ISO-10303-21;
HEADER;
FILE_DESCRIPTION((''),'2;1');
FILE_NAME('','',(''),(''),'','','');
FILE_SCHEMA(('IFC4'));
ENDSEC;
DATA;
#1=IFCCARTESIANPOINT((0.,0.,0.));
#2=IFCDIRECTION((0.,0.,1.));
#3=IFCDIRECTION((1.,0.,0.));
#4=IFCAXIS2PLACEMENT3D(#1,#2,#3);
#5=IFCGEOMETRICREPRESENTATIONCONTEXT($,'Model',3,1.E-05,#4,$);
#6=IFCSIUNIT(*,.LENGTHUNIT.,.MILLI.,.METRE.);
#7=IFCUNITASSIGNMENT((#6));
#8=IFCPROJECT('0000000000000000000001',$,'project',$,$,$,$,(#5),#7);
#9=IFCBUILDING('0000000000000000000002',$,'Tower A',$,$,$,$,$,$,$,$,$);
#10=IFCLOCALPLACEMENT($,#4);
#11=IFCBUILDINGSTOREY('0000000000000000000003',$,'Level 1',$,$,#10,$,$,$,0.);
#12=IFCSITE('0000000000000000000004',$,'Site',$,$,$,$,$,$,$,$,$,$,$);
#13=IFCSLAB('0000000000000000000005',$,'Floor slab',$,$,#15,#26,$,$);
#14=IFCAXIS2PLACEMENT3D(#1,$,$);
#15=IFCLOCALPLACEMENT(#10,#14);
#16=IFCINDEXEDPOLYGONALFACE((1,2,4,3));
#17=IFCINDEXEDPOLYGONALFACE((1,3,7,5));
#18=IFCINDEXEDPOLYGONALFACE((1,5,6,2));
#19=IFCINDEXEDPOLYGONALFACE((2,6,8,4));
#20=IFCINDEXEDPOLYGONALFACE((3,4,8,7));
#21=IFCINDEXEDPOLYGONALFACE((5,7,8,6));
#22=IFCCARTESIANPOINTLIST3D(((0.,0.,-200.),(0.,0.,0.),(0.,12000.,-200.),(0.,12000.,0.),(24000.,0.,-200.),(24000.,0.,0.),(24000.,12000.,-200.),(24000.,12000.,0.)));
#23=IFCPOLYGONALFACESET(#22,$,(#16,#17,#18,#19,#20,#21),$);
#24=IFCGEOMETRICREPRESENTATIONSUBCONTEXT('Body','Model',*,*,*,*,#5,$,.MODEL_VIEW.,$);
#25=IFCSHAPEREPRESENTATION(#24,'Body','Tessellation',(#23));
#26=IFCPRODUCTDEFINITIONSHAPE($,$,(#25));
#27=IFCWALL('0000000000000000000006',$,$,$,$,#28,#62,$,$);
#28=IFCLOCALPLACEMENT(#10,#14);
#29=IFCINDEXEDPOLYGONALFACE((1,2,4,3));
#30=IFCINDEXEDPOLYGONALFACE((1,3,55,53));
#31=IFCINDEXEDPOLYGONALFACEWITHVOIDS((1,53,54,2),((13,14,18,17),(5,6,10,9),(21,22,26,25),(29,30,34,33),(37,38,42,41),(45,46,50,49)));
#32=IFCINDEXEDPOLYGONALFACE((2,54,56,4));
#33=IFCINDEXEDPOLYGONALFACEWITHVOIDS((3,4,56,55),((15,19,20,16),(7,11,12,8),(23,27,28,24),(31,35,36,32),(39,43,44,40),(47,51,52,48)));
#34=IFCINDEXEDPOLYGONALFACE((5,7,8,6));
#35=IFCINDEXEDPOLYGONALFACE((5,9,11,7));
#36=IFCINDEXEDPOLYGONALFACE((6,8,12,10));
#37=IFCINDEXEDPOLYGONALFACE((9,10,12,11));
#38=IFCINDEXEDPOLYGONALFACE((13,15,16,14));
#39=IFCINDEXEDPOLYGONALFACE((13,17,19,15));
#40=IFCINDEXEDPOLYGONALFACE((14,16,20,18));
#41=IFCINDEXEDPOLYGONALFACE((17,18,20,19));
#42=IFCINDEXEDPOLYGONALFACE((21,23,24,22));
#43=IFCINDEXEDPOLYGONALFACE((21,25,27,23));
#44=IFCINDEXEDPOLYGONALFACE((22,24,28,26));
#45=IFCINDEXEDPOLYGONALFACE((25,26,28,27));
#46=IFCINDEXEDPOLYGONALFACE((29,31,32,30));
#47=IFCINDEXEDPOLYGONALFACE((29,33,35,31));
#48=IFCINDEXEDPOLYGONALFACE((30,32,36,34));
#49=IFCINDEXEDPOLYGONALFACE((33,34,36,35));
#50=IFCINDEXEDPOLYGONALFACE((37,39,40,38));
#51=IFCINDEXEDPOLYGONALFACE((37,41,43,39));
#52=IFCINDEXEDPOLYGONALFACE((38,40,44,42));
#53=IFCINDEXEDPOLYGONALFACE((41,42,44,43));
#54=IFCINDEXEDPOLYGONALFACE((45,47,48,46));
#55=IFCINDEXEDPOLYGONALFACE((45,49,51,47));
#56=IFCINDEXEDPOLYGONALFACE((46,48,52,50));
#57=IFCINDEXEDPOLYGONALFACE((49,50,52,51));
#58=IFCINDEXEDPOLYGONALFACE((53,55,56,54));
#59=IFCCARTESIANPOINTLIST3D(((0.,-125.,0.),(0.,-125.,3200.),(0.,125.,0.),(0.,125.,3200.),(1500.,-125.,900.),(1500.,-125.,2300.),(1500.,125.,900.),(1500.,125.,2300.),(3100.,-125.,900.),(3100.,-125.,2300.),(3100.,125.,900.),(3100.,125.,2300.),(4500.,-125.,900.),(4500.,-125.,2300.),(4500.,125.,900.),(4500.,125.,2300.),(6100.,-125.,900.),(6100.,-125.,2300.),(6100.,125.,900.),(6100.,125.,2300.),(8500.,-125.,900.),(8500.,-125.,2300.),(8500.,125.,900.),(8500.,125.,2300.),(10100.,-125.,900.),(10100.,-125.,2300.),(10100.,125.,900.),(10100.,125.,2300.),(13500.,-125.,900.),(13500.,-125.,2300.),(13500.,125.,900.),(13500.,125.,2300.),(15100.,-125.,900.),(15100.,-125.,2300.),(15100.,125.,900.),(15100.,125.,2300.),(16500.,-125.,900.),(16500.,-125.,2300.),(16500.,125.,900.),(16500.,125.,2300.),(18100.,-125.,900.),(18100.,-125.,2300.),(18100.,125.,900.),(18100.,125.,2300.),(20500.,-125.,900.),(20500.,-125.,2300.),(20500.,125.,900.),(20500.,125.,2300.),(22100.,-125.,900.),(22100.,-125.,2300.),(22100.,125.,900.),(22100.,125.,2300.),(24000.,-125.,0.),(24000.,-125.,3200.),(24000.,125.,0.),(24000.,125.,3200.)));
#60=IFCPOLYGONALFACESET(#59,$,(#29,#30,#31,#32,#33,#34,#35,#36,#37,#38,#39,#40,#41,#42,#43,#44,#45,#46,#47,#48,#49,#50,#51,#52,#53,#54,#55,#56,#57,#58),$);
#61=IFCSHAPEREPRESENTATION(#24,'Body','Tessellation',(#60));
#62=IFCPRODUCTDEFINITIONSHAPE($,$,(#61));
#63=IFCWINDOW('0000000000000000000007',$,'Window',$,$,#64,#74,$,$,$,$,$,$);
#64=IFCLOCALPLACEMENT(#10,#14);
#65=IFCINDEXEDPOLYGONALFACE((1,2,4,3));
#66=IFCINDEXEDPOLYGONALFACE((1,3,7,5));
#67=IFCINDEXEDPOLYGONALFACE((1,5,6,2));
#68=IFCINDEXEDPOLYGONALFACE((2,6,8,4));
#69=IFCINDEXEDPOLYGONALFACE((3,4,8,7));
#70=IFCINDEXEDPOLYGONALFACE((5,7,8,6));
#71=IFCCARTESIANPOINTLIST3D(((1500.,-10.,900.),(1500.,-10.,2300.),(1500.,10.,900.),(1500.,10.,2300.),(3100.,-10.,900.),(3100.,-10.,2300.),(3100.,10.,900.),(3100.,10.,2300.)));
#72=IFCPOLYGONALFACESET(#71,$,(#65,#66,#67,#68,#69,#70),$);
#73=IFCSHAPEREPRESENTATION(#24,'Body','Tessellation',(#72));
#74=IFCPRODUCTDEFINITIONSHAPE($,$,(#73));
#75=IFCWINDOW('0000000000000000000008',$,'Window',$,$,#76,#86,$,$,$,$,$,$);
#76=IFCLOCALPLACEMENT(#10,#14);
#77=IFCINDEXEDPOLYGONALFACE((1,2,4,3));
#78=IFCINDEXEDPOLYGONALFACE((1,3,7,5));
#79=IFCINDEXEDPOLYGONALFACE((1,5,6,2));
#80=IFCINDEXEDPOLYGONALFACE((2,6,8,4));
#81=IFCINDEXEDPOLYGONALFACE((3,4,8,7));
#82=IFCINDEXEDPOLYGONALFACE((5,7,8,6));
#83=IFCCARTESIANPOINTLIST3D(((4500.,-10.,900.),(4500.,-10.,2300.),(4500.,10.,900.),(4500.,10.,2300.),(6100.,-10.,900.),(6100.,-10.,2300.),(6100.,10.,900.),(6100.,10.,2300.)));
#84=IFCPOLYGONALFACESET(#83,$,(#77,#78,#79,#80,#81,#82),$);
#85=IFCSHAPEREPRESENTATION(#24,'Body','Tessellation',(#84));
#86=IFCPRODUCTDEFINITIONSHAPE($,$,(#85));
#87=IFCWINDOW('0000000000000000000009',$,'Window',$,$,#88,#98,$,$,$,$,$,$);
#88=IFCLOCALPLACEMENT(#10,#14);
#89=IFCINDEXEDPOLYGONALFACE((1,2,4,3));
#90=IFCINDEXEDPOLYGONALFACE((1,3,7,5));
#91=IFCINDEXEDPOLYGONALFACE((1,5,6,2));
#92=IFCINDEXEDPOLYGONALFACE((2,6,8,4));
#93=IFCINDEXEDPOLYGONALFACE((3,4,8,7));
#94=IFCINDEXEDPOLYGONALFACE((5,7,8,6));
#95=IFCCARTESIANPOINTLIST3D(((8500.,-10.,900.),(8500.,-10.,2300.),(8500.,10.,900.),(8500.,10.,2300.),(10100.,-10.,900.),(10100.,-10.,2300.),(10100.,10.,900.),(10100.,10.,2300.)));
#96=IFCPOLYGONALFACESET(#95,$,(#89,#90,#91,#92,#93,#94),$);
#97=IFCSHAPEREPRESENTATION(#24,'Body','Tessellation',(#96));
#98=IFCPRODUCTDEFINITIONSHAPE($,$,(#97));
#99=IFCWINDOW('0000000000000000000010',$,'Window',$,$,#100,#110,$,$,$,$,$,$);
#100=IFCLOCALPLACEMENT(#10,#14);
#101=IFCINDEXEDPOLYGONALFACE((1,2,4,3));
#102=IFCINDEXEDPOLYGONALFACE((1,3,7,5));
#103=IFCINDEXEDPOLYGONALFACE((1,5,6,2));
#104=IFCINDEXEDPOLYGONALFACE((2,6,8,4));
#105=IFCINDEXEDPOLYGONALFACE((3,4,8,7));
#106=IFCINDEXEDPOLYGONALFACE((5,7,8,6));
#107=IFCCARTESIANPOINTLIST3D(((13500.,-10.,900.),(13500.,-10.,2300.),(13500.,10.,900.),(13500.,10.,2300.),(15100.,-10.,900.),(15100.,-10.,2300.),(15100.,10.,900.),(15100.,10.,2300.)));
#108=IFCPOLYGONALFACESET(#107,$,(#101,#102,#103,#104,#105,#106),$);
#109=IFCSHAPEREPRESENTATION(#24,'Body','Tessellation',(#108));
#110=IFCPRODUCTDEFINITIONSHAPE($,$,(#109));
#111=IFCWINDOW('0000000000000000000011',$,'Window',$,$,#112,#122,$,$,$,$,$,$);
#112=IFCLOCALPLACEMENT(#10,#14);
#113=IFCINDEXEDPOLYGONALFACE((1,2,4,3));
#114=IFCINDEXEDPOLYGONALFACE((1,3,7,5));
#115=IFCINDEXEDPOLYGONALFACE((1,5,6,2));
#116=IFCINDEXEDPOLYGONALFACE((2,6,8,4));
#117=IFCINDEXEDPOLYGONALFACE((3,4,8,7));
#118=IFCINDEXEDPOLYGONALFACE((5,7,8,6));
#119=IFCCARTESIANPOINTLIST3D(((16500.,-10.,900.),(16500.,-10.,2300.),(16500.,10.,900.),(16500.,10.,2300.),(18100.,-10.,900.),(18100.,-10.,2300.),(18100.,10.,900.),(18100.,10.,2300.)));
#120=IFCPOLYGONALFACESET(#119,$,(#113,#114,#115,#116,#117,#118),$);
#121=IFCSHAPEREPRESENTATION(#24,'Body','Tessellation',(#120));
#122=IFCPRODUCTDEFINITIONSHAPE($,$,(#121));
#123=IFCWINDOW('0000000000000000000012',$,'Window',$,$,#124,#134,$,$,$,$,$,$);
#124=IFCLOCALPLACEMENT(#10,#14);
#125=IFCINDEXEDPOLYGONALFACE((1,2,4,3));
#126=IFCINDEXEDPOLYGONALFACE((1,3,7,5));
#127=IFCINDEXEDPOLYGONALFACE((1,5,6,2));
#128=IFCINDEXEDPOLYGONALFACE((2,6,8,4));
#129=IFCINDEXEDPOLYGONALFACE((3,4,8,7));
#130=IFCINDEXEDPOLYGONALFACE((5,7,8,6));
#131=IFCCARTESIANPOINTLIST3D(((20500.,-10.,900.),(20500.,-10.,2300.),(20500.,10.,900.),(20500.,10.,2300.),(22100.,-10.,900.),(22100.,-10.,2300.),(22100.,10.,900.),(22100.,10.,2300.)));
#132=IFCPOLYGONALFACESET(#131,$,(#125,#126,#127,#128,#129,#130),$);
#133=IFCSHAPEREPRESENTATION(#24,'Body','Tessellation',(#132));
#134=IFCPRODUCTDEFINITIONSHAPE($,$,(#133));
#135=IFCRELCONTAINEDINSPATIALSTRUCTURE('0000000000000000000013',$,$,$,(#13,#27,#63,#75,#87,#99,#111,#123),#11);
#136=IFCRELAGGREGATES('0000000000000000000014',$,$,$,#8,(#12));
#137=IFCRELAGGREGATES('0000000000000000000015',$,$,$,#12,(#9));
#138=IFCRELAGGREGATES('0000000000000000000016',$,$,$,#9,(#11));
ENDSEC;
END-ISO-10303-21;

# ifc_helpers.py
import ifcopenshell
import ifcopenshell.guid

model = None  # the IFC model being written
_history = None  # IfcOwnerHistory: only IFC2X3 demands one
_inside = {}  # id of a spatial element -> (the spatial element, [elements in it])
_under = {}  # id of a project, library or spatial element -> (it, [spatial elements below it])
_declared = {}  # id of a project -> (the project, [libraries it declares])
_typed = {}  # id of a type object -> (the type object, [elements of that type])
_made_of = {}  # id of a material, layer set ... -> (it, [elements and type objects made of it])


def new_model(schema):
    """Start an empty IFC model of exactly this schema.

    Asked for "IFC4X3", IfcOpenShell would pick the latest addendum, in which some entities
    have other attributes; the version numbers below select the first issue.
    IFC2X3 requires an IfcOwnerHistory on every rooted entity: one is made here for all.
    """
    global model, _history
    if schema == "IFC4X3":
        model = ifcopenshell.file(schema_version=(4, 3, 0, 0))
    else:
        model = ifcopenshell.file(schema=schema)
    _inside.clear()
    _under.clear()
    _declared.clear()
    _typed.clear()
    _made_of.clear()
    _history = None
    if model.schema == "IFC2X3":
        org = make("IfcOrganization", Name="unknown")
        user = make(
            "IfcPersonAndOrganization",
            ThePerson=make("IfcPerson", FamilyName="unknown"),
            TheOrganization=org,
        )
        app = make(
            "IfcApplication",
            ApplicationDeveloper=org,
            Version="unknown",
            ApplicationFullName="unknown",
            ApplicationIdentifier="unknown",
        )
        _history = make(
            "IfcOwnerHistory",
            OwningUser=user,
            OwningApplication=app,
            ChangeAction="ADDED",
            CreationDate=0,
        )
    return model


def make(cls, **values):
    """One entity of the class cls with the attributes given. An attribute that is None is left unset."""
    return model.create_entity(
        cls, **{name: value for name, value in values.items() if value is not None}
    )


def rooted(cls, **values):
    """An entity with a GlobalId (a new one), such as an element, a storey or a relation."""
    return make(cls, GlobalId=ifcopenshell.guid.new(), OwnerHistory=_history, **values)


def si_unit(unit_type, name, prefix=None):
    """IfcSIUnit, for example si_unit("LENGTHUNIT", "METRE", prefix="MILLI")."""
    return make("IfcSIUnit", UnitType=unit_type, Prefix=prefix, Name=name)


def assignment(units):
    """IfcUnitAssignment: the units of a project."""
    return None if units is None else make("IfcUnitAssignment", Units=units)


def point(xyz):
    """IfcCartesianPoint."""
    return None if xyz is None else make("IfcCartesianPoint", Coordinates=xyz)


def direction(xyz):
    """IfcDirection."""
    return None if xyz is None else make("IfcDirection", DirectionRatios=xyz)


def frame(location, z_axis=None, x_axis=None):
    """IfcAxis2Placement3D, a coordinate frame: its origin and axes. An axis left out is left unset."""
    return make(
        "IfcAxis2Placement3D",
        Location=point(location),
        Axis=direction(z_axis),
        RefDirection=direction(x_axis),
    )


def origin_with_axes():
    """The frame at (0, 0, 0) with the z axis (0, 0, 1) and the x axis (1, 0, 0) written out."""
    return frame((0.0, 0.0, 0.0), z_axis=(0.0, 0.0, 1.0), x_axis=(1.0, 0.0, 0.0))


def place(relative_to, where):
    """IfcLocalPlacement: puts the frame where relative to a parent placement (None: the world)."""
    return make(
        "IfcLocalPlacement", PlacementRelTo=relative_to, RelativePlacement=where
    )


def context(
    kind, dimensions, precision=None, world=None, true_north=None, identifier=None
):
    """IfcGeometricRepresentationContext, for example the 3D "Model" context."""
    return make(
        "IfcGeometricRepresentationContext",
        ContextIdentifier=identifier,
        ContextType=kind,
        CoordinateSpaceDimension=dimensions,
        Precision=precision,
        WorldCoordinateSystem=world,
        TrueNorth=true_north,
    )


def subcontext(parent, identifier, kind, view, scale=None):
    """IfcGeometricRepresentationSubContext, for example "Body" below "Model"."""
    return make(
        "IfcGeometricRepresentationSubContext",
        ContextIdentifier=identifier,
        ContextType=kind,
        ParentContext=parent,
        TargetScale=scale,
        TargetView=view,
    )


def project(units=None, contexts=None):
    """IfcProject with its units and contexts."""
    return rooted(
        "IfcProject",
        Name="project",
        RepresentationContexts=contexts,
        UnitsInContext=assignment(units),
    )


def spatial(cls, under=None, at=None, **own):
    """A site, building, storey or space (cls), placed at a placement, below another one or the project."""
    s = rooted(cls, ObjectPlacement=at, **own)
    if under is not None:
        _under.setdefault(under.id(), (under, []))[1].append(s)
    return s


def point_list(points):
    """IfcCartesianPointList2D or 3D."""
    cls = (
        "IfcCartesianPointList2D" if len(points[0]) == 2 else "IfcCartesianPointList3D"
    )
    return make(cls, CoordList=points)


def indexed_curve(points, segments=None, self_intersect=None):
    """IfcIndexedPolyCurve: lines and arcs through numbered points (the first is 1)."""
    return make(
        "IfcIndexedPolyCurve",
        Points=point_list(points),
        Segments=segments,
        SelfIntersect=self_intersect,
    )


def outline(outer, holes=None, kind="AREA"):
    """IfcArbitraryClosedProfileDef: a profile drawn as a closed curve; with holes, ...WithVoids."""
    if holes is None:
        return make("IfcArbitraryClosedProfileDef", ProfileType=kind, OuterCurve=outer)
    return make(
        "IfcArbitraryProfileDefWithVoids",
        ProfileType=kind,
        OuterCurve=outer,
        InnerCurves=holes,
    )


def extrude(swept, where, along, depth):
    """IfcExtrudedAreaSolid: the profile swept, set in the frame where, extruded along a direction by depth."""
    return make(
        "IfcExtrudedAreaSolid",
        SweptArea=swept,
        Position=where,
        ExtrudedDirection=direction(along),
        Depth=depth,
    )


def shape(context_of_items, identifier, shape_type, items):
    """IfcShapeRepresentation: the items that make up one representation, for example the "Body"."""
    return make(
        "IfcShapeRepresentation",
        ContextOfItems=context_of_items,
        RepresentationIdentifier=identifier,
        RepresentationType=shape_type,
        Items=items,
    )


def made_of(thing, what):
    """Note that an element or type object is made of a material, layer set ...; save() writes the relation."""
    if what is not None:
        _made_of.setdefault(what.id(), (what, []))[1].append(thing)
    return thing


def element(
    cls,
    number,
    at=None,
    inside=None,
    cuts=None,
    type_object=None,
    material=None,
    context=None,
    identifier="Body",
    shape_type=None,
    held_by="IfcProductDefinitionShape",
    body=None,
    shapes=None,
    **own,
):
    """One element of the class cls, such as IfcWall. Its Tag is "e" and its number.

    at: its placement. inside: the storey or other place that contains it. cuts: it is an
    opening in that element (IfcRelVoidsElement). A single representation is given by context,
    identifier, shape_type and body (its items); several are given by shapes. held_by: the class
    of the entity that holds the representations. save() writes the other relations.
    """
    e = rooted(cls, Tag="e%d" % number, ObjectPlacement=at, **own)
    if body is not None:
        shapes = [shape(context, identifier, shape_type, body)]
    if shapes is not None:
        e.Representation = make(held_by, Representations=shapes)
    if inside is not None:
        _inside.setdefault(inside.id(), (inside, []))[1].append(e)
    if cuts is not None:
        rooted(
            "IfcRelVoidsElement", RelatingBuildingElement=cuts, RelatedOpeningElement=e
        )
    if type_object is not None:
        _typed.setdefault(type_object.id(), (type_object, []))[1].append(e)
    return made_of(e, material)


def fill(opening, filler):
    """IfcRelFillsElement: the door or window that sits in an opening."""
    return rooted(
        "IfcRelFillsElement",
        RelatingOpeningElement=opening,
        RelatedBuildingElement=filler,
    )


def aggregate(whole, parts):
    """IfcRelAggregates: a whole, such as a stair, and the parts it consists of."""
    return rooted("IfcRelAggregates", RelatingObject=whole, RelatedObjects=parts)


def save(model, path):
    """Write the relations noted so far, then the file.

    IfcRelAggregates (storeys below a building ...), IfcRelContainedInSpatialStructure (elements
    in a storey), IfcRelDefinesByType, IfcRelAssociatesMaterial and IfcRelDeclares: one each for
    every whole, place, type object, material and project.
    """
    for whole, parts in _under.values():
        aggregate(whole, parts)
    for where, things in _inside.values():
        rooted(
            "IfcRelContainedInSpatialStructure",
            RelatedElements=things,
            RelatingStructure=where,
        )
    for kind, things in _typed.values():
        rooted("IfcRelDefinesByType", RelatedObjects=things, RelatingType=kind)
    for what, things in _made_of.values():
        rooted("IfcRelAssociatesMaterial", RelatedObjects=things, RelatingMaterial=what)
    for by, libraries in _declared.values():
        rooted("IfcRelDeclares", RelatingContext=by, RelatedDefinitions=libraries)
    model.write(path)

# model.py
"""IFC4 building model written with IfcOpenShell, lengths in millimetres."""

from ifc_helpers import new_model, si_unit, frame, origin_with_axes, place, context, subcontext, project, spatial, indexed_curve, outline, extrude, element, fill, save


model = new_model("IFC4")

# Units and contexts
model_context = context("Model", 3, precision=1e-05, world=origin_with_axes())
body_context = subcontext(model_context, "Body", "Model", "MODEL_VIEW")
ifc_project = project(units=[si_unit("LENGTHUNIT", "METRE", prefix="MILLI")], contexts=[model_context])

# Site, building, storey
site = spatial("IfcSite", under=ifc_project, Name="Site")
building = spatial("IfcBuilding", under=site, Name="Tower A")
storey_placement = place(None, origin_with_axes())
storey = spatial("IfcBuildingStorey", under=building, at=storey_placement, Name="Level 1", Elevation=0.0)

# Slab
slab_placement = place(storey_placement, frame((0.0, 0.0, -200.0), z_axis=(0.0, 0.0, 1.0), x_axis=(1.0, 0.0, 0.0)))
element("IfcSlab", 1, at=slab_placement, inside=storey, Name="Floor slab", context=body_context, shape_type="SweptSolid", body=[
    extrude(outline(indexed_curve([(0.0, 0.0), (24000.0, 0.0), (24000.0, 12000.0), (0.0, 12000.0)])), None, (0.0, 0.0, 1.0), 200.0),
])

# Wall, openings, windows
wall_1_placement = place(storey_placement, frame((0.0, -125.0, 0.0), z_axis=(0.0, 0.0, 1.0), x_axis=(1.0, 0.0, 0.0)))
wall_1 = element("IfcWall", 2, at=wall_1_placement, inside=storey, context=body_context, shape_type="SweptSolid", body=[
    extrude(outline(indexed_curve([(0.0, 0.0), (0.0, 250.0), (24000.0, 250.0), (24000.0, 0.0), (0.0, 0.0)], self_intersect=False)), origin_with_axes(), (0.0, 0.0, 1.0), 3200.0),
])
opening_1_placement = place(wall_1_placement, frame((1500.0, 0.0, 900.0), z_axis=(0.0, 0.0, 1.0), x_axis=(1.0, 0.0, 0.0)))
opening_1 = element("IfcOpeningElement", 3, at=opening_1_placement, cuts=wall_1, context=body_context, shape_type="SweptSolid", body=[
    extrude(outline(indexed_curve([(0.0, 0.0), (0.0, 250.0), (1600.0, 250.0), (1600.0, 0.0), (0.0, 0.0)], self_intersect=False)), origin_with_axes(), (0.0, 0.0, 1.0), 1400.0),
])
opening_2_placement = place(wall_1_placement, frame((4500.0, 0.0, 900.0), z_axis=(0.0, 0.0, 1.0), x_axis=(1.0, 0.0, 0.0)))
opening_2 = element("IfcOpeningElement", 4, at=opening_2_placement, cuts=wall_1, context=body_context, shape_type="SweptSolid", body=[
    extrude(outline(indexed_curve([(0.0, 0.0), (0.0, 250.0), (1600.0, 250.0), (1600.0, 0.0), (0.0, 0.0)], self_intersect=False)), origin_with_axes(), (0.0, 0.0, 1.0), 1400.0),
])
opening_3_placement = place(wall_1_placement, frame((8500.0, 0.0, 900.0), z_axis=(0.0, 0.0, 1.0), x_axis=(1.0, 0.0, 0.0)))
opening_3 = element("IfcOpeningElement", 5, at=opening_3_placement, cuts=wall_1, context=body_context, shape_type="SweptSolid", body=[
    extrude(outline(indexed_curve([(0.0, 0.0), (0.0, 250.0), (1600.0, 250.0), (1600.0, 0.0), (0.0, 0.0)], self_intersect=False)), origin_with_axes(), (0.0, 0.0, 1.0), 1400.0),
])
opening_4_placement = place(wall_1_placement, frame((13500.0, 0.0, 900.0), z_axis=(0.0, 0.0, 1.0), x_axis=(1.0, 0.0, 0.0)))
opening_4 = element("IfcOpeningElement", 6, at=opening_4_placement, cuts=wall_1, context=body_context, shape_type="SweptSolid", body=[
    extrude(outline(indexed_curve([(0.0, 0.0), (0.0, 250.0), (1600.0, 250.0), (1600.0, 0.0), (0.0, 0.0)], self_intersect=False)), origin_with_axes(), (0.0, 0.0, 1.0), 1400.0),
])
opening_5_placement = place(wall_1_placement, frame((16500.0, 0.0, 900.0), z_axis=(0.0, 0.0, 1.0), x_axis=(1.0, 0.0, 0.0)))
opening_5 = element("IfcOpeningElement", 7, at=opening_5_placement, cuts=wall_1, context=body_context, shape_type="SweptSolid", body=[
    extrude(outline(indexed_curve([(0.0, 0.0), (0.0, 250.0), (1600.0, 250.0), (1600.0, 0.0), (0.0, 0.0)], self_intersect=False)), origin_with_axes(), (0.0, 0.0, 1.0), 1400.0),
])
opening_6_placement = place(wall_1_placement, frame((20500.0, 0.0, 900.0), z_axis=(0.0, 0.0, 1.0), x_axis=(1.0, 0.0, 0.0)))
opening_6 = element("IfcOpeningElement", 8, at=opening_6_placement, cuts=wall_1, context=body_context, shape_type="SweptSolid", body=[
    extrude(outline(indexed_curve([(0.0, 0.0), (0.0, 250.0), (1600.0, 250.0), (1600.0, 0.0), (0.0, 0.0)], self_intersect=False)), origin_with_axes(), (0.0, 0.0, 1.0), 1400.0),
])
window_1_placement = place(storey_placement, frame((1500.0, -10.0, 900.0), z_axis=(0.0, 0.0, 1.0), x_axis=(1.0, 0.0, 0.0)))
window_1 = element("IfcWindow", 9, at=window_1_placement, inside=storey, Name="Window", context=body_context, shape_type="SweptSolid", body=[
    extrude(outline(indexed_curve([(0.0, 0.0), (0.0, 20.0), (1600.0, 20.0), (1600.0, 0.0), (0.0, 0.0)], self_intersect=False)), origin_with_axes(), (0.0, 0.0, 1.0), 1400.0),
])
fill(opening_1, window_1)
window_2_placement = place(storey_placement, frame((4500.0, -10.0, 900.0), z_axis=(0.0, 0.0, 1.0), x_axis=(1.0, 0.0, 0.0)))
window_2 = element("IfcWindow", 10, at=window_2_placement, inside=storey, Name="Window", context=body_context, shape_type="SweptSolid", body=[
    extrude(outline(indexed_curve([(0.0, 0.0), (0.0, 20.0), (1600.0, 20.0), (1600.0, 0.0), (0.0, 0.0)], self_intersect=False)), origin_with_axes(), (0.0, 0.0, 1.0), 1400.0),
])
fill(opening_2, window_2)
window_3_placement = place(storey_placement, frame((8500.0, -10.0, 900.0), z_axis=(0.0, 0.0, 1.0), x_axis=(1.0, 0.0, 0.0)))
window_3 = element("IfcWindow", 11, at=window_3_placement, inside=storey, Name="Window", context=body_context, shape_type="SweptSolid", body=[
    extrude(outline(indexed_curve([(0.0, 0.0), (0.0, 20.0), (1600.0, 20.0), (1600.0, 0.0), (0.0, 0.0)], self_intersect=False)), origin_with_axes(), (0.0, 0.0, 1.0), 1400.0),
])
fill(opening_3, window_3)
window_4_placement = place(storey_placement, frame((13500.0, -10.0, 900.0), z_axis=(0.0, 0.0, 1.0), x_axis=(1.0, 0.0, 0.0)))
window_4 = element("IfcWindow", 12, at=window_4_placement, inside=storey, Name="Window", context=body_context, shape_type="SweptSolid", body=[
    extrude(outline(indexed_curve([(0.0, 0.0), (0.0, 20.0), (1600.0, 20.0), (1600.0, 0.0), (0.0, 0.0)], self_intersect=False)), origin_with_axes(), (0.0, 0.0, 1.0), 1400.0),
])
fill(opening_4, window_4)
window_5_placement = place(storey_placement, frame((16500.0, -10.0, 900.0), z_axis=(0.0, 0.0, 1.0), x_axis=(1.0, 0.0, 0.0)))
window_5 = element("IfcWindow", 13, at=window_5_placement, inside=storey, Name="Window", context=body_context, shape_type="SweptSolid", body=[
    extrude(outline(indexed_curve([(0.0, 0.0), (0.0, 20.0), (1600.0, 20.0), (1600.0, 0.0), (0.0, 0.0)], self_intersect=False)), origin_with_axes(), (0.0, 0.0, 1.0), 1400.0),
])
fill(opening_5, window_5)
window_6_placement = place(storey_placement, frame((20500.0, -10.0, 900.0), z_axis=(0.0, 0.0, 1.0), x_axis=(1.0, 0.0, 0.0)))
window_6 = element("IfcWindow", 14, at=window_6_placement, inside=storey, Name="Window", context=body_context, shape_type="SweptSolid", body=[
    extrude(outline(indexed_curve([(0.0, 0.0), (0.0, 20.0), (1600.0, 20.0), (1600.0, 0.0), (0.0, 0.0)], self_intersect=False)), origin_with_axes(), (0.0, 0.0, 1.0), 1400.0),
])
fill(opening_6, window_6)

save(model, "model.ifc")
